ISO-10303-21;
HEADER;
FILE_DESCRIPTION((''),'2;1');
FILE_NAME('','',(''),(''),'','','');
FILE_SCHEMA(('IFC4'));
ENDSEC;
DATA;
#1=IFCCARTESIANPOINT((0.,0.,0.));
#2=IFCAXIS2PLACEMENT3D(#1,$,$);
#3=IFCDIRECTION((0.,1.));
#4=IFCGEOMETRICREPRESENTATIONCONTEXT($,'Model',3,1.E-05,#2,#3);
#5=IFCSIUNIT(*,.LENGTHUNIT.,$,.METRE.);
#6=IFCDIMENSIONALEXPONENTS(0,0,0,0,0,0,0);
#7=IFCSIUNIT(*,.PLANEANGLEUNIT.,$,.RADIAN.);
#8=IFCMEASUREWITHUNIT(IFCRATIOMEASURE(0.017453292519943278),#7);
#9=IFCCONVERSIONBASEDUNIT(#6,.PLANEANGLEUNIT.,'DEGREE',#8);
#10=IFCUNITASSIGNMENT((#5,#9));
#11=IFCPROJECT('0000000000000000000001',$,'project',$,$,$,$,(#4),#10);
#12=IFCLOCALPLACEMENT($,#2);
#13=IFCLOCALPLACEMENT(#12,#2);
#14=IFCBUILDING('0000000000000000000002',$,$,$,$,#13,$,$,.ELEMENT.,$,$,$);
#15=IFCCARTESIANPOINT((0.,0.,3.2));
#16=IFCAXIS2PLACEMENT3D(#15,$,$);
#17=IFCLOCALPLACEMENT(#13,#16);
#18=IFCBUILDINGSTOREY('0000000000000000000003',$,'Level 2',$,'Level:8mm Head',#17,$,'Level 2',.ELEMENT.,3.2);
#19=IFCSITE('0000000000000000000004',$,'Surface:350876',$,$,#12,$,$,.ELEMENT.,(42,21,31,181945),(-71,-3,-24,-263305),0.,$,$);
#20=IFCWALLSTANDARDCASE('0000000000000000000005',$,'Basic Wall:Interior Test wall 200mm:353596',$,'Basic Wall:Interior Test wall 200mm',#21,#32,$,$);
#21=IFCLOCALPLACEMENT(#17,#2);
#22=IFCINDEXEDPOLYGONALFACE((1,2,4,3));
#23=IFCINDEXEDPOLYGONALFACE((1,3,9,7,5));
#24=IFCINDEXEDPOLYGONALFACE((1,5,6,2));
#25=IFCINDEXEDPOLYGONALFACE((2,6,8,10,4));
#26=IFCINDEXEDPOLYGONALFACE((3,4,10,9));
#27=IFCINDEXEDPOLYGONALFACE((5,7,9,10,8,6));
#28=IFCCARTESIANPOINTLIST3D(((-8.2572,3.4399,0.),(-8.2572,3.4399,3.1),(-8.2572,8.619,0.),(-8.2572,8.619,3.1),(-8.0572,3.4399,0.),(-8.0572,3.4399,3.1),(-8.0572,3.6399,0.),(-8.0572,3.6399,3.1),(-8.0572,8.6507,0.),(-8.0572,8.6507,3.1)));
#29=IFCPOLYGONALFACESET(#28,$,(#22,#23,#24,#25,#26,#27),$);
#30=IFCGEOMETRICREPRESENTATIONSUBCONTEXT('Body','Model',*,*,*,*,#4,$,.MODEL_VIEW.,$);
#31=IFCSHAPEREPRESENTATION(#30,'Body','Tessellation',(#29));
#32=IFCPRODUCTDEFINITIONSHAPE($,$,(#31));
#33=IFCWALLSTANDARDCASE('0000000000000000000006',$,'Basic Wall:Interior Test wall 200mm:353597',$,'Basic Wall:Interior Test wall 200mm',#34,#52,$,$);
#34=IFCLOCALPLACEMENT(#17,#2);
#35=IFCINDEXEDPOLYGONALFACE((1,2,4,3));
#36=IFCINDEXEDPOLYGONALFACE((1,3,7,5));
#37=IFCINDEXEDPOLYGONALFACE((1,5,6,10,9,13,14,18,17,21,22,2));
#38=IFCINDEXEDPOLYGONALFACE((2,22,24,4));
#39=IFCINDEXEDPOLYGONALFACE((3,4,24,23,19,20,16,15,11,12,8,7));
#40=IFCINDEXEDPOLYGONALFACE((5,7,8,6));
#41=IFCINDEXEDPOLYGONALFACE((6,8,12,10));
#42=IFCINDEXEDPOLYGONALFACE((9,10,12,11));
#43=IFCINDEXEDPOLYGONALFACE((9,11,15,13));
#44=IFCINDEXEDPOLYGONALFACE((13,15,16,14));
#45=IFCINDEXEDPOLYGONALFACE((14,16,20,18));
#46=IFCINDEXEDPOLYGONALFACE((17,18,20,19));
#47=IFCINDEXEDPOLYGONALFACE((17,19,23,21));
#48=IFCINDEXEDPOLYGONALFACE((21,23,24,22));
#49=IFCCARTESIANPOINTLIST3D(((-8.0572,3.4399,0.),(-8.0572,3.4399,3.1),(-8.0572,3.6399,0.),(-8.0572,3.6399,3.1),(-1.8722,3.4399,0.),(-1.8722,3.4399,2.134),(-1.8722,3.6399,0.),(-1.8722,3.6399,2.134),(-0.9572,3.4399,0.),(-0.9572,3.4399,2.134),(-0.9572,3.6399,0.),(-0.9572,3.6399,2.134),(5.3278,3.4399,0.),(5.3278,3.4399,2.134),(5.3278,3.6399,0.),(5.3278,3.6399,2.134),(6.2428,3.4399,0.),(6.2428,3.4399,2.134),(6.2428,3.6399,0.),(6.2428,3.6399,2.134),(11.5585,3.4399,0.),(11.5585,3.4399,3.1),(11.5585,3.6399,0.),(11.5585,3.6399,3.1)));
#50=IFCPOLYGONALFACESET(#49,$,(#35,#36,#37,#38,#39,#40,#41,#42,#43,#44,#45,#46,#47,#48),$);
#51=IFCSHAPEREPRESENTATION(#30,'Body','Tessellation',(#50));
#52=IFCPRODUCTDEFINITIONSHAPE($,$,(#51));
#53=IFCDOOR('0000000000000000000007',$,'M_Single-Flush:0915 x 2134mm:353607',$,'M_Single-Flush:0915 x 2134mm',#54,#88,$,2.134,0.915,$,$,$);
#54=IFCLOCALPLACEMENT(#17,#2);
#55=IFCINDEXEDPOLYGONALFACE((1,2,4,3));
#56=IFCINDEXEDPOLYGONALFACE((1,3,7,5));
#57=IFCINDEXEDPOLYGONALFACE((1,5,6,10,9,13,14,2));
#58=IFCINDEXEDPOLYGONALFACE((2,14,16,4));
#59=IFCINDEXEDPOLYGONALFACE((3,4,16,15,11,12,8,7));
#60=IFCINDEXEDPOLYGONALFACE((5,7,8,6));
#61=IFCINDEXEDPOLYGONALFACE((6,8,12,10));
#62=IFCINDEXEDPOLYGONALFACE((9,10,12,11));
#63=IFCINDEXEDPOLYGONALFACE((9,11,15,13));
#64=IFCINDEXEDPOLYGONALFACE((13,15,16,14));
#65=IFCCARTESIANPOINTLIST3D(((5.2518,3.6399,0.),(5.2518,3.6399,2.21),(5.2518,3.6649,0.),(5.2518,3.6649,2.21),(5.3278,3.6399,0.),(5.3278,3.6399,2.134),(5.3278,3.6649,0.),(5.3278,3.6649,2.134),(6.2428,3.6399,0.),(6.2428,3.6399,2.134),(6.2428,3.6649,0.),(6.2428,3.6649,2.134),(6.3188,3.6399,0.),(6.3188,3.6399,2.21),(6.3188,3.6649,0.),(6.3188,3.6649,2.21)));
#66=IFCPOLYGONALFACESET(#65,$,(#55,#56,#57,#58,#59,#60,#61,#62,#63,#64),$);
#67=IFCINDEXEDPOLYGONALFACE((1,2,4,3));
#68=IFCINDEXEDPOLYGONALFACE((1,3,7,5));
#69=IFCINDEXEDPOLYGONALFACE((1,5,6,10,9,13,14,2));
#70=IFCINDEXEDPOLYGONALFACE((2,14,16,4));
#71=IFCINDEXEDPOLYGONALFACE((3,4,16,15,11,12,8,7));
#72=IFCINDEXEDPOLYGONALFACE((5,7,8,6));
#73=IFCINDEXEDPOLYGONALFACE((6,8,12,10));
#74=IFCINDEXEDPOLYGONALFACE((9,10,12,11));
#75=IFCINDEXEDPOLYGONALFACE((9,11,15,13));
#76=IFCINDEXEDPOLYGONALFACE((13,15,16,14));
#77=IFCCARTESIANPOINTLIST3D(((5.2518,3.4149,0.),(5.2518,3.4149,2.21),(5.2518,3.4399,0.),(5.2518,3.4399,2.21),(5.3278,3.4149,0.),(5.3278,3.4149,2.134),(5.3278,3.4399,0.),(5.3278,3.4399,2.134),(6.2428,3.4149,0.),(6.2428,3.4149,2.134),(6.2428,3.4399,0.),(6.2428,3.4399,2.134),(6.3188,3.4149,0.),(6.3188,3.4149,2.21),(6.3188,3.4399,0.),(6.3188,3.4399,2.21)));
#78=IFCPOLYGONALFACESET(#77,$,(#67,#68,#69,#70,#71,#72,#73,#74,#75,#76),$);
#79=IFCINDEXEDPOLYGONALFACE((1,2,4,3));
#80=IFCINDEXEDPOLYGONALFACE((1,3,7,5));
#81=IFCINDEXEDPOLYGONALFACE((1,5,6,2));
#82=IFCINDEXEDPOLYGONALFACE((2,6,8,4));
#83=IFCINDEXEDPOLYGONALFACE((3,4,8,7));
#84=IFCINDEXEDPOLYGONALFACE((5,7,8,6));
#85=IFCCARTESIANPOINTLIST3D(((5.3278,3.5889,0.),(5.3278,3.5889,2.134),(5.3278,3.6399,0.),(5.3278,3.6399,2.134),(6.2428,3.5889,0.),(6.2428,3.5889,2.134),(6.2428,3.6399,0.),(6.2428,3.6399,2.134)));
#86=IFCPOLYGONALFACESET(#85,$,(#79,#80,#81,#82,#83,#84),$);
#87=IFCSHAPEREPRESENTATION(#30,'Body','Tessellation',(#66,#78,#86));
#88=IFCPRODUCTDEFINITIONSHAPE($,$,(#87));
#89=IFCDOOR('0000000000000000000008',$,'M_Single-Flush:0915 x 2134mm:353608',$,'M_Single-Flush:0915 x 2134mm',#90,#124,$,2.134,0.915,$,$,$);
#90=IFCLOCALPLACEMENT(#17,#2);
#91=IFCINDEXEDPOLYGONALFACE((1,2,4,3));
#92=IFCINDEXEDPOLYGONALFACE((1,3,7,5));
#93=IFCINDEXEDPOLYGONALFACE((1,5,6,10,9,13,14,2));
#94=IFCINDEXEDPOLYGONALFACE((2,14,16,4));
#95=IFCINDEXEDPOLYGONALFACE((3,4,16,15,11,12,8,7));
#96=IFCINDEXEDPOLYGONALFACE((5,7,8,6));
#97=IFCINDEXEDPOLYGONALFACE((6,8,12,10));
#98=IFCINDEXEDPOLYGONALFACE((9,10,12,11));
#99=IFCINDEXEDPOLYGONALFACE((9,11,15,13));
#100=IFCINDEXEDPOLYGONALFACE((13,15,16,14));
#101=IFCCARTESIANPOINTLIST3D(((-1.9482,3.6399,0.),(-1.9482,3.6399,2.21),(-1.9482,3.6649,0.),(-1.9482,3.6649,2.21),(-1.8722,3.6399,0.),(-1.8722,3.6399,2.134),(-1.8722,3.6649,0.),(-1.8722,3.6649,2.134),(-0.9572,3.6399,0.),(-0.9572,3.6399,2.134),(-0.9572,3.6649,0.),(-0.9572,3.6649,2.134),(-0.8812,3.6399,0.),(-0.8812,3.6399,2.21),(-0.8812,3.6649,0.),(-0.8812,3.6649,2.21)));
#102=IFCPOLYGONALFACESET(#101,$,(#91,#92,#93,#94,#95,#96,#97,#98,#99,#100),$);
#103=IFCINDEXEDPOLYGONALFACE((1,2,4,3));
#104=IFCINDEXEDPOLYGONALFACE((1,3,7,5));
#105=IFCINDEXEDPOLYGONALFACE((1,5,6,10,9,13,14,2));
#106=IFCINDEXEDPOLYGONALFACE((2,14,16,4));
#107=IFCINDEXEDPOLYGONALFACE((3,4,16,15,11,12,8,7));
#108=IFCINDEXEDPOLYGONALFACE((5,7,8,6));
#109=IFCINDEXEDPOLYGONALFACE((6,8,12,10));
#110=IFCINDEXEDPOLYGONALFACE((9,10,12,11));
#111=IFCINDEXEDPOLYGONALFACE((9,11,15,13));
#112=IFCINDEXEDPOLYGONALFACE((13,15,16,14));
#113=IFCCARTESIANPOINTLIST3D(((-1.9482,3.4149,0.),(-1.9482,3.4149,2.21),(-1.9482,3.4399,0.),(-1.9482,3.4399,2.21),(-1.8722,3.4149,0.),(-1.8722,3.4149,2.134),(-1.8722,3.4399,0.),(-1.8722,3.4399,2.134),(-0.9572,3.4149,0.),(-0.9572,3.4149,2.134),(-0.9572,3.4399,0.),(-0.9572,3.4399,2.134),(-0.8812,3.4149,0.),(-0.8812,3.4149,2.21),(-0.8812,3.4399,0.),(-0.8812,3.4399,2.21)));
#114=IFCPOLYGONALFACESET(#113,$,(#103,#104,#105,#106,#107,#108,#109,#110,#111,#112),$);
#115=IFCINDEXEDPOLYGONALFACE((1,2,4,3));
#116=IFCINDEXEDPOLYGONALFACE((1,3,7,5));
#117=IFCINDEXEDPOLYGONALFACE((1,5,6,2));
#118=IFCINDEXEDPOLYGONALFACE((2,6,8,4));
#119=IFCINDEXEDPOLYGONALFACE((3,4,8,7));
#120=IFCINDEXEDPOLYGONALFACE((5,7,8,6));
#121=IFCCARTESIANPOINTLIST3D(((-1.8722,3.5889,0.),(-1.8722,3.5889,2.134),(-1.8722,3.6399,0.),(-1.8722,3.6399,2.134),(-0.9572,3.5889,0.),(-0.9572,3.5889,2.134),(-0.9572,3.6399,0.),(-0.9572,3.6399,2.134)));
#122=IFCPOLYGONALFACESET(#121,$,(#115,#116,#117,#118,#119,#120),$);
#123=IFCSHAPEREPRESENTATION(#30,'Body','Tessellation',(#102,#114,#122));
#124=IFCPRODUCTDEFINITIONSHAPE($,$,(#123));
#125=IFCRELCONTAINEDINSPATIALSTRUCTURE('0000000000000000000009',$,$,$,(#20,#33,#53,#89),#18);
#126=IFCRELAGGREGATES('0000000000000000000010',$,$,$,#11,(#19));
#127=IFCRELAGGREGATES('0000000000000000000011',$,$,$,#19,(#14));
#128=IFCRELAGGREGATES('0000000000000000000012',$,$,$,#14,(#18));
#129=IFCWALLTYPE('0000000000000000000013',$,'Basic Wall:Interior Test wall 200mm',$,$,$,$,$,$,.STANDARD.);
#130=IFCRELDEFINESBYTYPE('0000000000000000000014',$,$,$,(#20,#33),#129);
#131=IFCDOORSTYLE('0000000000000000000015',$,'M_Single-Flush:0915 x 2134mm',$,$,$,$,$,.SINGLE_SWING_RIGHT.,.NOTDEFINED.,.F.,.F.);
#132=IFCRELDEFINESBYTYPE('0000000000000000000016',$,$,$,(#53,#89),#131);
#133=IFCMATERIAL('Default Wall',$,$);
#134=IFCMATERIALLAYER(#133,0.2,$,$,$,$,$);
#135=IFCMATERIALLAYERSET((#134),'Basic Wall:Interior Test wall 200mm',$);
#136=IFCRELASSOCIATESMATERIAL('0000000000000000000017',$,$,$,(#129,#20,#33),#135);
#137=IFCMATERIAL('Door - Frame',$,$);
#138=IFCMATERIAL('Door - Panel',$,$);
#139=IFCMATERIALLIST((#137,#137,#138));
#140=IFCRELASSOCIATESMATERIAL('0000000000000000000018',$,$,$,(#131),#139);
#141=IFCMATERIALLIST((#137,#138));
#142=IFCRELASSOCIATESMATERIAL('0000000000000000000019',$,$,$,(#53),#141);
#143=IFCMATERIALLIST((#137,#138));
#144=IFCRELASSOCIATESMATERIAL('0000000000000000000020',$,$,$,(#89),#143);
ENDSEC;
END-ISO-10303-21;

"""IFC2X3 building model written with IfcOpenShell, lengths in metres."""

from ifc_helpers import new_model, entity, si_unit, converted_unit, direction, frame, frame_2d, origin, place, context, subcontext, project, spatial, polyline, rectangle, outline, extrude, source, transform, mapped, material, material_list, layer, layer_set, layer_usage, type_object, type_shapes, element, fill, save


model = new_model("IFC2X3")

# Units and contexts
model_context = context("Model", 3, precision=1e-05, world=origin(), true_north=direction((0.0, 1.0)))
body_context = subcontext(model_context, "Body", "Model", "MODEL_VIEW")
ifc_project = project(units=[si_unit("LENGTHUNIT", "METRE"), converted_unit("PLANEANGLEUNIT", "DEGREE", entity("IfcRatioMeasure", 0.017453292519943278), si_unit("PLANEANGLEUNIT", "RADIAN"), dimensions=[0, 0, 0, 0, 0, 0, 0])], contexts=[model_context])

# Site, building, storey
site_placement = place(None, origin())
site = spatial("IfcSite", under=ifc_project, at=site_placement, Name="Surface:350876", CompositionType="ELEMENT", RefLatitude=(42, 21, 31, 181945), RefLongitude=(-71, -3, -24, -263305), RefElevation=0.0)
building_placement = place(site_placement, origin())
building = spatial("IfcBuilding", under=site, at=building_placement, CompositionType="ELEMENT")
storey_placement = place(building_placement, frame((0.0, 0.0, 3.2)))
storey = spatial("IfcBuildingStorey", under=building, at=storey_placement, Name="Level 2", ObjectType="Level:8mm Head", LongName="Level 2", CompositionType="ELEMENT", Elevation=3.2)

# Shared definitions
ifc_material_1 = material(Name="Default Wall")

# Wall
ifc_layer_1 = layer(ifc_material_1, 0.2)
ifc_layer_set_1 = layer_set([ifc_layer_1], Name="Basic Wall:Interior Test wall 200mm")
ifc_layer_usage_1 = layer_usage(ifc_layer_set_1, "AXIS2", "NEGATIVE", 0.1)
wall_type_1 = type_object("IfcWallType", Name="Basic Wall:Interior Test wall 200mm", PredefinedType="STANDARD", material=ifc_layer_set_1)
wall_1_placement = place(storey_placement, frame((-8.1572, 8.6507, 0.0), z_axis=(0.0, 0.0, 1.0), x_axis=(0.0, -1.0, 0.0)))
element("IfcWallStandardCase", 1, at=wall_1_placement, inside=storey, type_object=wall_type_1, material=ifc_layer_usage_1, Name="Basic Wall:Interior Test wall 200mm:353596", ObjectType="Basic Wall:Interior Test wall 200mm", context=body_context, shape_type="SweptSolid", body=[
    extrude(outline(polyline([(5.2107, -0.1), (5.2107, 0.1), (5.0107, 0.1), (0.0, 0.1), (0.0317, -0.1), (5.2107, -0.1)])), origin(), (0.0, 0.0, 1.0), 3.1),
])

# Wall, openings, doors
ifc_layer_usage_2 = layer_usage(ifc_layer_set_1, "AXIS2", "NEGATIVE", 0.1)
wall_2_placement = place(storey_placement, frame((-8.0572, 3.5399, 0.0)))
wall_2 = element("IfcWallStandardCase", 2, at=wall_2_placement, inside=storey, type_object=wall_type_1, material=ifc_layer_usage_2, Name="Basic Wall:Interior Test wall 200mm:353597", ObjectType="Basic Wall:Interior Test wall 200mm", context=body_context, shape_type="SweptSolid", body=[
    extrude(rectangle(XDim=19.6158, YDim=0.2, at=frame_2d((9.8079, 0.0), x_axis=(-1.0, 0.0))), origin(), (0.0, 0.0, 1.0), 3.1),
])
opening_1_placement = place(wall_2_placement, frame((13.385, -0.1, 0.0)))
opening_1 = element("IfcOpeningElement", 3, at=opening_1_placement, cuts=wall_2, ObjectType="Opening", context=body_context, shape_type="SweptSolid", body=[
    extrude(rectangle(XDim=0.915, YDim=2.134, at=frame_2d((1.067, 0.4575), x_axis=(0.0, 1.0))), frame((0.0, 0.0, 0.0), z_axis=(0.0, 1.0, 0.0), x_axis=(0.0, 0.0, 1.0)), (0.0, 0.0, 1.0), 0.2),
])
opening_2_placement = place(wall_2_placement, frame((6.185, -0.1, 0.0)))
opening_2 = element("IfcOpeningElement", 4, at=opening_2_placement, cuts=wall_2, ObjectType="Opening", context=body_context, shape_type="SweptSolid", body=[
    extrude(rectangle(XDim=0.915, YDim=2.134, at=frame_2d((1.067, 0.4575), x_axis=(0.0, 1.0))), frame((0.0, 0.0, 0.0), z_axis=(0.0, 1.0, 0.0), x_axis=(0.0, 0.0, 1.0)), (0.0, 0.0, 1.0), 0.2),
])
ifc_material_2 = material(Name="Door - Frame")
ifc_material_3 = material(Name="Door - Panel")
ifc_material_list_1 = material_list([ifc_material_2, ifc_material_3])
ifc_material_list_2 = material_list([ifc_material_2, ifc_material_2, ifc_material_3])
door_style_1 = type_object("IfcDoorStyle", Name="M_Single-Flush:0915 x 2134mm", ConstructionType="NOTDEFINED", OperationType="SINGLE_SWING_RIGHT", ParameterTakesPrecedence=False, Sizeable=False, material=ifc_material_list_2)
shared_shape_1 = source(origin(), body_context, "Body", "SweptSolid", [
    extrude(outline(polyline([(-0.5335, -1.124), (0.5335, -1.124), (0.5335, 1.086), (0.4575, 1.086), (0.4575, -1.048), (-0.4575, -1.048), (-0.4575, 1.086), (-0.5335, 1.086), (-0.5335, -1.124)])), frame((0.4575, 0.2, 1.086), z_axis=(0.0, 1.0, 0.0), x_axis=(1.0, 0.0, 0.0)), (0.0, 0.0, 1.0), 0.025),
    extrude(outline(polyline([(-1.124, -0.5335), (1.086, -0.5335), (1.086, -0.4575), (-1.048, -0.4575), (-1.048, 0.4575), (1.086, 0.4575), (1.086, 0.5335), (-1.124, 0.5335), (-1.124, -0.5335)])), frame((0.4575, -0.025, 1.086), z_axis=(0.0, 1.0, 0.0), x_axis=(0.0, 0.0, -1.0)), (0.0, 0.0, 1.0), 0.025),
    extrude(rectangle(XDim=0.051, YDim=0.915, at=frame_2d((0.0, 0.0), x_axis=(1.0, 0.0))), frame((0.4575, 0.1745, 0.0), z_axis=(0.0, 0.0, 1.0), x_axis=(0.0, 1.0, 0.0)), (0.0, 0.0, 1.0), 2.134),
])
type_shapes(door_style_1, [shared_shape_1])
door_1_placement = place(opening_1_placement, origin())
door_1 = element("IfcDoor", 5, at=door_1_placement, inside=storey, type_object=door_style_1, material=ifc_material_list_1, Name="M_Single-Flush:0915 x 2134mm:353607", ObjectType="M_Single-Flush:0915 x 2134mm", OverallHeight=2.134, OverallWidth=0.915, context=body_context, shape_type="MappedRepresentation", body=[
    mapped(shared_shape_1, transform((0.0, 0.0, 0.0), scale=1.0)),
])
fill(opening_1, door_1)
ifc_material_list_3 = material_list([ifc_material_2, ifc_material_3])
door_2_placement = place(opening_2_placement, origin())
door_2 = element("IfcDoor", 6, at=door_2_placement, inside=storey, type_object=door_style_1, material=ifc_material_list_3, Name="M_Single-Flush:0915 x 2134mm:353608", ObjectType="M_Single-Flush:0915 x 2134mm", OverallHeight=2.134, OverallWidth=0.915, context=body_context, shape_type="MappedRepresentation", body=[
    mapped(shared_shape_1, transform((0.0, 0.0, 0.0), scale=1.0)),
])
fill(opening_2, door_2)

save(model, "model.ifc")
